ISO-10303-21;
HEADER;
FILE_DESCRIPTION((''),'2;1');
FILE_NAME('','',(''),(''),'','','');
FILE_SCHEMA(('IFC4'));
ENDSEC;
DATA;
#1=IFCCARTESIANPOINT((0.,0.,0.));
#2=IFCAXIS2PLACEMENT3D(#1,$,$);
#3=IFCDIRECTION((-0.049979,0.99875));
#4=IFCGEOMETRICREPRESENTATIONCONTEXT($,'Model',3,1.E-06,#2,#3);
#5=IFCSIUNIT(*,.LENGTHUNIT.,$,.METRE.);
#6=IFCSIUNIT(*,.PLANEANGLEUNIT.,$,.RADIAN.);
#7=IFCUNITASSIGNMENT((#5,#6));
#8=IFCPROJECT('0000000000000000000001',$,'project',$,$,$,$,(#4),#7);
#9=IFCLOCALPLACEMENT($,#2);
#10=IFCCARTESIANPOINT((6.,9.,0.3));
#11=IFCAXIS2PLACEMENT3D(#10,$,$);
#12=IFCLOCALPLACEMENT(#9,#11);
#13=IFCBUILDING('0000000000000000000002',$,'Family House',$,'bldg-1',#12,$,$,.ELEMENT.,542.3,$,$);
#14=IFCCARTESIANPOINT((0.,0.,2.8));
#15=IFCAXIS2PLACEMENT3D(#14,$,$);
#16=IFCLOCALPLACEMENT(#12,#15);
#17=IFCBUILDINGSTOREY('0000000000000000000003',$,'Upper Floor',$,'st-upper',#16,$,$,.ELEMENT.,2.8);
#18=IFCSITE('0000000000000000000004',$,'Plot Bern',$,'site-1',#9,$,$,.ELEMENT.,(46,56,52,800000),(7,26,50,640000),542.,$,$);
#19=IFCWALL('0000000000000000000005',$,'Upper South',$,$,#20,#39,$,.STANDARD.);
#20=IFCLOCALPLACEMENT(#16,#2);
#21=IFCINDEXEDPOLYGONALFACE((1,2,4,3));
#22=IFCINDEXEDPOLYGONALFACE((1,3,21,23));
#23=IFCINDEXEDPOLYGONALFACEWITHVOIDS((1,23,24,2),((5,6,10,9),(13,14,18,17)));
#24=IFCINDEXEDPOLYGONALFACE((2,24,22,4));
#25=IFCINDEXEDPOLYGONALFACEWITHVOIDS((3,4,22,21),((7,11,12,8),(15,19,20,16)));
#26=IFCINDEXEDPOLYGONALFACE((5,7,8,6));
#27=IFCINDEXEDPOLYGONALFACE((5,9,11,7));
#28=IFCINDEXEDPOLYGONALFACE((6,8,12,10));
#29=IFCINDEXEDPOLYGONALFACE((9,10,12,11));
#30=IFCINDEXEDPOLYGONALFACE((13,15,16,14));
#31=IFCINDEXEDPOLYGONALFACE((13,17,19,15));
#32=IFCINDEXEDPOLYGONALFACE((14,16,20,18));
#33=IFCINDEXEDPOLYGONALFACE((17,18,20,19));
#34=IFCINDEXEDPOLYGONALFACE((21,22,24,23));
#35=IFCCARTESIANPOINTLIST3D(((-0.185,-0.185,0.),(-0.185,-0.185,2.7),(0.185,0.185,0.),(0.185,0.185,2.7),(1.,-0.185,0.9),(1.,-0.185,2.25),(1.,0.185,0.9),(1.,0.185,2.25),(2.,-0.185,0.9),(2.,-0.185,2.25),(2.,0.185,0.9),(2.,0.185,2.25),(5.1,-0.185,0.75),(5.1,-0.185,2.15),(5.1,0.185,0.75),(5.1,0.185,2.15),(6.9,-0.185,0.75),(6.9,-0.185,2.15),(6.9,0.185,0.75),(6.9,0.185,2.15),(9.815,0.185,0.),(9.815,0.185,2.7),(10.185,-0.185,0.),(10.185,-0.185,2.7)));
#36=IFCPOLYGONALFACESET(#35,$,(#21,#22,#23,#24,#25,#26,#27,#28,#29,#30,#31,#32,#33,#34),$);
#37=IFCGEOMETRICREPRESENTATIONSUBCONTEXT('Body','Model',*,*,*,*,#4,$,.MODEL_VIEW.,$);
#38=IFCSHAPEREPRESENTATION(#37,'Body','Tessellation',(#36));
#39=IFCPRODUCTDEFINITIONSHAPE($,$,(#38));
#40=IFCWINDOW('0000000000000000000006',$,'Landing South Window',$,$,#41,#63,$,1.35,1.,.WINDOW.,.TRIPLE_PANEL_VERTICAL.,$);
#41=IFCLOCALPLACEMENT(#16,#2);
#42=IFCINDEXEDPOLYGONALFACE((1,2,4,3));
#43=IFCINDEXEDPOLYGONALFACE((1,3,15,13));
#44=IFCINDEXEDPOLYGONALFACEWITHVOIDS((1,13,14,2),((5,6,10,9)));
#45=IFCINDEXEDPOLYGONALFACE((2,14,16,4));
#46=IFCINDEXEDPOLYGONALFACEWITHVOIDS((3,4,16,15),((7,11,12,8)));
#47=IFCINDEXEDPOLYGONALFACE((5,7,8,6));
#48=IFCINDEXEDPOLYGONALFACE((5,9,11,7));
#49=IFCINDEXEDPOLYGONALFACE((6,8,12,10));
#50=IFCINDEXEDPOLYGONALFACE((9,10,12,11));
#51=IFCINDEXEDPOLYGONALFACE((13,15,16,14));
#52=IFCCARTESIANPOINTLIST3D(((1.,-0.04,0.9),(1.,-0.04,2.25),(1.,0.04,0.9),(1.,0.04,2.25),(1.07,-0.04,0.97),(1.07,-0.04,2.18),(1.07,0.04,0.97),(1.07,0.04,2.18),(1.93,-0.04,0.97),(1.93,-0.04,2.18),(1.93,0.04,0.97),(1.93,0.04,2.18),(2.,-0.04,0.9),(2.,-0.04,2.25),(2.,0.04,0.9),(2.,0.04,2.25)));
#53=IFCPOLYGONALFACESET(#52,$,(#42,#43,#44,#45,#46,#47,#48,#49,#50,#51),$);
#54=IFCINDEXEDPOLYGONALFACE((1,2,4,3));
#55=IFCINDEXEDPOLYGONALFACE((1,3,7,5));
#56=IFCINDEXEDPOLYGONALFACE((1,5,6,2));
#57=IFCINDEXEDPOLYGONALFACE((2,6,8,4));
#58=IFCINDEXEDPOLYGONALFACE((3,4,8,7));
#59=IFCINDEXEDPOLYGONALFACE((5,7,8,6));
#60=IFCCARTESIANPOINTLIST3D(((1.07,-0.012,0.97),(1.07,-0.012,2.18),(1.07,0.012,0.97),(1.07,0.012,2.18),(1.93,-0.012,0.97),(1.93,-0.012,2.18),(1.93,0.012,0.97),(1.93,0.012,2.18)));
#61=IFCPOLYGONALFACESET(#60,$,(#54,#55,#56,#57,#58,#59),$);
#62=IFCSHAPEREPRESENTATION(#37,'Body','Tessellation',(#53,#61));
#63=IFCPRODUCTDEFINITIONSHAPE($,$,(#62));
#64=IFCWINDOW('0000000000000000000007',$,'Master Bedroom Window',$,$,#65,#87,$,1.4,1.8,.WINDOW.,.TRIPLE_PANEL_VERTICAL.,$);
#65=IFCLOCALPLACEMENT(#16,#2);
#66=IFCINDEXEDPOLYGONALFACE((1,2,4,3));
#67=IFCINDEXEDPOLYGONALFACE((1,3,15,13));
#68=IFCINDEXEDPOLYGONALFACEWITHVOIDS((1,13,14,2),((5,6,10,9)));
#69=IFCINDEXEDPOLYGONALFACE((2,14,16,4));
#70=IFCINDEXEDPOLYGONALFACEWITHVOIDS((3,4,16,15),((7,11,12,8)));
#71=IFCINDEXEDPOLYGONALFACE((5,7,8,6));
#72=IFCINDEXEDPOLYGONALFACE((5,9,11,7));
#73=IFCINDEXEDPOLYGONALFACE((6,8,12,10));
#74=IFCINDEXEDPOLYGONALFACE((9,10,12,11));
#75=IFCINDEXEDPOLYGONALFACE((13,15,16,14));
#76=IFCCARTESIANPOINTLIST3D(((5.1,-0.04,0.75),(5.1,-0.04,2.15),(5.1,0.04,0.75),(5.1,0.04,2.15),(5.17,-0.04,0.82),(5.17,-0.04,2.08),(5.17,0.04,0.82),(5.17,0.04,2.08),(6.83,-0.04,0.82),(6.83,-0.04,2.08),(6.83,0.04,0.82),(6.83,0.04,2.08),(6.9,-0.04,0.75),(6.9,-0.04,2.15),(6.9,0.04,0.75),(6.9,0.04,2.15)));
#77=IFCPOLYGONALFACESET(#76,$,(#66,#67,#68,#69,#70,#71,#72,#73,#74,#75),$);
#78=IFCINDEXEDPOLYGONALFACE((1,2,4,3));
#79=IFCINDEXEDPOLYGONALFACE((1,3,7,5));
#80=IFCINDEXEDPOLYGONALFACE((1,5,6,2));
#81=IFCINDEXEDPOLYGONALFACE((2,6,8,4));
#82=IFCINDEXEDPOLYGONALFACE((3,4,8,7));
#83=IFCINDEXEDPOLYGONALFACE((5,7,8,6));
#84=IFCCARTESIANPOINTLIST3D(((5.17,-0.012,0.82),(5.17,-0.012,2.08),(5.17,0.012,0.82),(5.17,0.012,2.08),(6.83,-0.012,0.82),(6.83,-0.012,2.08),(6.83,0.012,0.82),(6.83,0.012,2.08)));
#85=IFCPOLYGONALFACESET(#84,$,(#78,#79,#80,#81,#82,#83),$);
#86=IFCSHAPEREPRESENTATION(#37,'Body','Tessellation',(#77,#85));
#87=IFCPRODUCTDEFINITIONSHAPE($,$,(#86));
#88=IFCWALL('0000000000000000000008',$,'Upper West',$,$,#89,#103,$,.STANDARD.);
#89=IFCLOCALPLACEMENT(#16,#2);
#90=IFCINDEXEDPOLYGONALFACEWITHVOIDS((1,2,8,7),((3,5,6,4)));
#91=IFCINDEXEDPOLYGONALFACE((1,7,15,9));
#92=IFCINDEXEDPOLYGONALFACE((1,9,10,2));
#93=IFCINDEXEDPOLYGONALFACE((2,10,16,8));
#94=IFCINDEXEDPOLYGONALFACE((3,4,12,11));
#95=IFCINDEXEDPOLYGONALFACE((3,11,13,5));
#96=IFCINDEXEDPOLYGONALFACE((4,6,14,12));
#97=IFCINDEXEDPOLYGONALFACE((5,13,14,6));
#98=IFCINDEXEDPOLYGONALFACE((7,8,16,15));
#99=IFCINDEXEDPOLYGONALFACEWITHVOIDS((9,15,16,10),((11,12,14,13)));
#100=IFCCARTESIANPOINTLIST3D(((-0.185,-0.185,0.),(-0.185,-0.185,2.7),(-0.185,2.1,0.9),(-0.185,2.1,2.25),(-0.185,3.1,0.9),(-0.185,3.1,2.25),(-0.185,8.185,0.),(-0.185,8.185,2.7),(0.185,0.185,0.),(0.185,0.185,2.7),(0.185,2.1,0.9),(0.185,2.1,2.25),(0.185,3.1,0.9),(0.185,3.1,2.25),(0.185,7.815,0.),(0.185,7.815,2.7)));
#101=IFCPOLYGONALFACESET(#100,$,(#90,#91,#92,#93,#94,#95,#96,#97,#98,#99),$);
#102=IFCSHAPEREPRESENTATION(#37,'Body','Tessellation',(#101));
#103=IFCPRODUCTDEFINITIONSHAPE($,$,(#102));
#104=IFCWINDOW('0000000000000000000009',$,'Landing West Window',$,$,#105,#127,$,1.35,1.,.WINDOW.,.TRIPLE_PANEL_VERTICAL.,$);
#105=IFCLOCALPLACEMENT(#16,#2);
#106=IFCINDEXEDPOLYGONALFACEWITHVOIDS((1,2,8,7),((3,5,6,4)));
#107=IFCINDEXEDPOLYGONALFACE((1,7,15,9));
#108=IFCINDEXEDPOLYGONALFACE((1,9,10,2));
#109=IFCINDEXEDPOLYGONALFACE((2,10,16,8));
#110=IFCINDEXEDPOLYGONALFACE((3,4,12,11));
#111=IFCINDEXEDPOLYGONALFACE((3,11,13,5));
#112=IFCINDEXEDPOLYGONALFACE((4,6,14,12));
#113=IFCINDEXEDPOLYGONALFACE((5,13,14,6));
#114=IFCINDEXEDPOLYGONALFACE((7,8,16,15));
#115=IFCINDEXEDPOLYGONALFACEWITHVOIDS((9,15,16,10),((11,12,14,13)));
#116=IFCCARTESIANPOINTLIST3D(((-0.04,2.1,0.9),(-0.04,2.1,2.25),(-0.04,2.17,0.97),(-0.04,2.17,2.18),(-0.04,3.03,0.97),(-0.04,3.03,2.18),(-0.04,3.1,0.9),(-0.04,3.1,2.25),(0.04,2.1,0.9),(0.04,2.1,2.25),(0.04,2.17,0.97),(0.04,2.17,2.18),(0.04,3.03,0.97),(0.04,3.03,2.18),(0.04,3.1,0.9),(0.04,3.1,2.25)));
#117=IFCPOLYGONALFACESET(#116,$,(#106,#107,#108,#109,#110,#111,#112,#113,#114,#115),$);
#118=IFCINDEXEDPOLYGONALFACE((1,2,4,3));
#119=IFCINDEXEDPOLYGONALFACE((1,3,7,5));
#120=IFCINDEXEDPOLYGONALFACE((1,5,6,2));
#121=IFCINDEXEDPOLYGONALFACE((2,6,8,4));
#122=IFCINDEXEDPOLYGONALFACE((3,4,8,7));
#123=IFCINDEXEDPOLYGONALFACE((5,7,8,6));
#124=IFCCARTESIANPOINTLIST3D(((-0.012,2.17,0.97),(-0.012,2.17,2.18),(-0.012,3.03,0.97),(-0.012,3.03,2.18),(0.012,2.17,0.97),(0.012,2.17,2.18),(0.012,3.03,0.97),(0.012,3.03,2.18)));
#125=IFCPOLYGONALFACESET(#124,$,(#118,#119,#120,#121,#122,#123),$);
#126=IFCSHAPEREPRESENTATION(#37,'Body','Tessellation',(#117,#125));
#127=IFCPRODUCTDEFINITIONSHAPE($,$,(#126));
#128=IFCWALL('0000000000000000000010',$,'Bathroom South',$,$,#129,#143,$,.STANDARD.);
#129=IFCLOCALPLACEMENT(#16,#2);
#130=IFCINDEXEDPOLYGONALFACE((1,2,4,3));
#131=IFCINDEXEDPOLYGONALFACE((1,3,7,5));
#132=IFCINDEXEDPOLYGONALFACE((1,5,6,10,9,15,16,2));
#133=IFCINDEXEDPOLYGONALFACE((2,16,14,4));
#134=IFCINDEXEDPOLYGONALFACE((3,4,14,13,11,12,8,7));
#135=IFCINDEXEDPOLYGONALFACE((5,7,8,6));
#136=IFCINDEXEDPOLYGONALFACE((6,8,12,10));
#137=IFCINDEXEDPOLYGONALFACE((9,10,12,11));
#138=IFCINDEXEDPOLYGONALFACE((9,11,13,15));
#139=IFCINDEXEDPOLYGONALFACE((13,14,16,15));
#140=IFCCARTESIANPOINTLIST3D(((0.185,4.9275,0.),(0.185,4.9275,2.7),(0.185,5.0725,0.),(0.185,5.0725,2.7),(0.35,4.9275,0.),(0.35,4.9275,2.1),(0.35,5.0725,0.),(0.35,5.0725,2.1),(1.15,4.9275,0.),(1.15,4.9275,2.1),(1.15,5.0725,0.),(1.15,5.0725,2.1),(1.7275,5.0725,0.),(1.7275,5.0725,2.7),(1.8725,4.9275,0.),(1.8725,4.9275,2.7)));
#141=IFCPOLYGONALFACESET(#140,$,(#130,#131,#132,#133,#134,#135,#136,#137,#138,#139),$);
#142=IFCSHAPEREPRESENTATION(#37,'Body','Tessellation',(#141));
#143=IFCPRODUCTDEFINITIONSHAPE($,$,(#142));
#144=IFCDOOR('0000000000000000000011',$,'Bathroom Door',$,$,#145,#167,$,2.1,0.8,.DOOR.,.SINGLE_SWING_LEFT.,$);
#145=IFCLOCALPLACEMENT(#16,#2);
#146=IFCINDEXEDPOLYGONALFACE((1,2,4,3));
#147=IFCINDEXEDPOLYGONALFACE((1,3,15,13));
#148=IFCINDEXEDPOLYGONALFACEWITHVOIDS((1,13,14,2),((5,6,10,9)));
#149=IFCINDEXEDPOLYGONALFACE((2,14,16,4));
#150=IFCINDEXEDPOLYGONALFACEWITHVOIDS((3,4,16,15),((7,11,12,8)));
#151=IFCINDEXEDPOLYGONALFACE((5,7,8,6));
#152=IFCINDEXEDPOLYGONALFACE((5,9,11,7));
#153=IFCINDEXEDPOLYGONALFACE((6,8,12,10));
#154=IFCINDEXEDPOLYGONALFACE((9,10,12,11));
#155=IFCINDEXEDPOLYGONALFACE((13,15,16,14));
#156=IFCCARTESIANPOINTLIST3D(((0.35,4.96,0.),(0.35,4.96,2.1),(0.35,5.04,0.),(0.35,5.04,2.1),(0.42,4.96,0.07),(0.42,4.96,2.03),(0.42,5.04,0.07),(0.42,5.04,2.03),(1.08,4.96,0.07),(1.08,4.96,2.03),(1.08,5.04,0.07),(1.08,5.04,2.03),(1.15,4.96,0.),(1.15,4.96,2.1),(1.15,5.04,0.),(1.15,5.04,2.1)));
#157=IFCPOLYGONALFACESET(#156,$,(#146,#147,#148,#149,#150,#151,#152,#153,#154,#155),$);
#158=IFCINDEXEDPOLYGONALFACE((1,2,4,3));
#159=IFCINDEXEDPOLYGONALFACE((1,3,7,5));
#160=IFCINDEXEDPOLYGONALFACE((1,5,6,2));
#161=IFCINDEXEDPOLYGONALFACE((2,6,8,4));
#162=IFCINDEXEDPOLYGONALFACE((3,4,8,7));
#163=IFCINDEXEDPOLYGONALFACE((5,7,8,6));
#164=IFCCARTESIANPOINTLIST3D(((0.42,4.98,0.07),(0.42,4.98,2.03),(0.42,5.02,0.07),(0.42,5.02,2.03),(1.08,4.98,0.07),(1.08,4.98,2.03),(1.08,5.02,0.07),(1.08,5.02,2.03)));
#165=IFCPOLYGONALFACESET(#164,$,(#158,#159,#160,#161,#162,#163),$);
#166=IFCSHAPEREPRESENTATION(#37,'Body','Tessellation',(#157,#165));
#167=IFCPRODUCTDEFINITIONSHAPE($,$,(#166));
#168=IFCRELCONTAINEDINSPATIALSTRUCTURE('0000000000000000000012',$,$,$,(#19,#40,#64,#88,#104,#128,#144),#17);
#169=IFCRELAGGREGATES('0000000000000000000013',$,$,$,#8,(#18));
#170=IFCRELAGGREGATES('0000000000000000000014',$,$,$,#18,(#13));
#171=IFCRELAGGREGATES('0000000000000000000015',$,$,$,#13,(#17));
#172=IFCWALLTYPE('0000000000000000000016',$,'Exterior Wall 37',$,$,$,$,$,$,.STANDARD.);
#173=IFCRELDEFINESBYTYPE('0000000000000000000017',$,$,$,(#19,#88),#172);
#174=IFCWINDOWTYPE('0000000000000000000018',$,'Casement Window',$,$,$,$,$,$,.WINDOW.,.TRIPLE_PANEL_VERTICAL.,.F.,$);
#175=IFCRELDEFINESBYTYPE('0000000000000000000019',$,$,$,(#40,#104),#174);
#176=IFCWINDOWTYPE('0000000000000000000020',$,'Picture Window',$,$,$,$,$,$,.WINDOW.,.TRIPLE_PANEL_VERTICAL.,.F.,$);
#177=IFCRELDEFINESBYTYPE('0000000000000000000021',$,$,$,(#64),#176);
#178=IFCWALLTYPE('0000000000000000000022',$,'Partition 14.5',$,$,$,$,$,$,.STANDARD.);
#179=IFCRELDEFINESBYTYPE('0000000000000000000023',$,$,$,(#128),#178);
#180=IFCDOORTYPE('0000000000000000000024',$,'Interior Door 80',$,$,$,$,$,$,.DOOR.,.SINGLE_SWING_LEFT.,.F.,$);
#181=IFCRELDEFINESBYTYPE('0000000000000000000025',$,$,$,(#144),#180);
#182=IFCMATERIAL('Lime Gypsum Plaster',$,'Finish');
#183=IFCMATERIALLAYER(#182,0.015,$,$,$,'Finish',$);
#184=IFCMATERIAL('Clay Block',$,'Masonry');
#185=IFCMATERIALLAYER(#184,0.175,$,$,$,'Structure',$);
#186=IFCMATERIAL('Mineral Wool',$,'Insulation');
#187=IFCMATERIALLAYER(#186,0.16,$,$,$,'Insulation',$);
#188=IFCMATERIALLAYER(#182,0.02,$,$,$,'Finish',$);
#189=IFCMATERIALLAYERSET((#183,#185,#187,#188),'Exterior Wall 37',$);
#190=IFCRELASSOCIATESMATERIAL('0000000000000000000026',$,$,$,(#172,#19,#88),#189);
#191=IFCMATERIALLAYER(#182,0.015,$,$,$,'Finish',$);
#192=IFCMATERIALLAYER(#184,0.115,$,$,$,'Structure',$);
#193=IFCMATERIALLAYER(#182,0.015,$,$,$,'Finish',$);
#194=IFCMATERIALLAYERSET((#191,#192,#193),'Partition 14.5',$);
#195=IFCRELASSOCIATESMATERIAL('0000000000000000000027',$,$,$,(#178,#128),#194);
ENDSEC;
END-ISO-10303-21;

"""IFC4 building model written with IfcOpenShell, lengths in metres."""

from ifc_helpers import new_model, si_unit, direction, frame, frame_2d, origin, origin_2d, place, context, subcontext, project, spatial, polyline, rectangle, outline, extrude, material, layer, layer_set, layer_usage, type_object, element, fill, save


model = new_model("IFC4")

# Units and contexts
model_context = context("Model", 3, precision=1e-06, world=origin(), true_north=direction((-0.049979, 0.99875)))
body_context = subcontext(model_context, "Body", "Model", "MODEL_VIEW")
ifc_project = project(units=[si_unit("LENGTHUNIT", "METRE"), si_unit("PLANEANGLEUNIT", "RADIAN")], contexts=[model_context])

# Site, building, storey
site_placement = place(None, origin())
site = spatial("IfcSite", under=ifc_project, at=site_placement, Name="Plot Bern", ObjectType="site-1", CompositionType="ELEMENT", RefLatitude=(46, 56, 52, 800000), RefLongitude=(7, 26, 50, 640000), RefElevation=542.0)
building_placement = place(site_placement, frame((6.0, 9.0, 0.3)))
building = spatial("IfcBuilding", under=site, at=building_placement, Name="Family House", ObjectType="bldg-1", CompositionType="ELEMENT", ElevationOfRefHeight=542.3)
storey_placement = place(building_placement, frame((0.0, 0.0, 2.8)))
storey = spatial("IfcBuildingStorey", under=building, at=storey_placement, Name="Upper Floor", ObjectType="st-upper", CompositionType="ELEMENT", Elevation=2.8)

# Shared definitions
ifc_material_1 = material(Name="Mineral Wool", Category="Insulation")

# Shared definitions
ifc_material_2 = material(Name="Lime Gypsum Plaster", Category="Finish")
ifc_layer_1 = layer(ifc_material_2, 0.015, Category="Finish")
ifc_material_3 = material(Name="Clay Block", Category="Masonry")
ifc_layer_2 = layer(ifc_material_3, 0.175, Category="Structure")
ifc_layer_3 = layer(ifc_material_1, 0.16, Category="Insulation")
ifc_layer_4 = layer(ifc_material_2, 0.02, Category="Finish")
ifc_layer_set_1 = layer_set([ifc_layer_1, ifc_layer_2, ifc_layer_3, ifc_layer_4], Name="Exterior Wall 37")
wall_type_1 = type_object("IfcWallType", Name="Exterior Wall 37", PredefinedType="STANDARD", material=ifc_layer_set_1)

# Shared definitions
window_type_1 = type_object("IfcWindowType", Name="Casement Window", ParameterTakesPrecedence=False, PartitioningType="TRIPLE_PANEL_VERTICAL", PredefinedType="WINDOW")

# Wall, openings, windows
ifc_layer_usage_1 = layer_usage(ifc_layer_set_1, "AXIS2", "NEGATIVE", 0.185)
wall_1_placement = place(storey_placement, origin())
wall_1 = element("IfcWall", 1, at=wall_1_placement, inside=storey, type_object=wall_type_1, material=ifc_layer_usage_1, Name="Upper South", PredefinedType="STANDARD", context=body_context, shape_type="SweptSolid", body=[
    extrude(outline(polyline([(-0.185, -0.185), (10.185, -0.185), (9.815, 0.185), (0.185, 0.185), (-0.185, -0.185)])), origin(), (0.0, 0.0, 1.0), 2.7),
])
opening_1_placement = place(wall_1_placement, frame((1.5, 0.0, 0.9), z_axis=(0.0, 0.0, 1.0), x_axis=(1.0, 0.0, 0.0)))
opening_1 = element("IfcOpeningElement", 2, at=opening_1_placement, cuts=wall_1, PredefinedType="OPENING", context=body_context, shape_type="SweptSolid", body=[
    extrude(rectangle(XDim=1.0, YDim=0.37, at=origin_2d()), origin(), (0.0, 0.0, 1.0), 1.35),
])
opening_2_placement = place(wall_1_placement, frame((6.0, 0.0, 0.75), z_axis=(0.0, 0.0, 1.0), x_axis=(1.0, 0.0, 0.0)))
opening_2 = element("IfcOpeningElement", 3, at=opening_2_placement, cuts=wall_1, PredefinedType="OPENING", context=body_context, shape_type="SweptSolid", body=[
    extrude(rectangle(XDim=1.8, YDim=0.37, at=origin_2d()), origin(), (0.0, 0.0, 1.0), 1.4),
])
window_1_placement = place(opening_1_placement, frame((0.0, 0.0, 0.0), z_axis=(0.0, -1.0, 0.0), x_axis=(1.0, 0.0, 0.0)))
window_1 = element("IfcWindow", 4, at=window_1_placement, inside=storey, type_object=window_type_1, Name="Landing South Window", OverallHeight=1.35, OverallWidth=1.0, PartitioningType="TRIPLE_PANEL_VERTICAL", PredefinedType="WINDOW", context=body_context, shape_type="SweptSolid", body=[
    extrude(outline(polyline([(-0.5, 0.0), (0.5, 0.0), (0.5, 1.35), (-0.5, 1.35), (-0.5, 0.0)]), holes=[polyline([(-0.43, 0.07), (0.43, 0.07), (0.43, 1.28), (-0.43, 1.28), (-0.43, 0.07)])]), frame((0.0, 0.0, -0.04)), (0.0, 0.0, 1.0), 0.08),
    extrude(rectangle(XDim=0.86, YDim=1.21, at=frame_2d((0.0, 0.675))), frame((0.0, 0.0, -0.012)), (0.0, 0.0, 1.0), 0.024),
])
fill(opening_1, window_1)
window_type_2 = type_object("IfcWindowType", Name="Picture Window", ParameterTakesPrecedence=False, PartitioningType="TRIPLE_PANEL_VERTICAL", PredefinedType="WINDOW")
window_2_placement = place(opening_2_placement, frame((0.0, 0.0, 0.0), z_axis=(0.0, -1.0, 0.0), x_axis=(1.0, 0.0, 0.0)))
window_2 = element("IfcWindow", 5, at=window_2_placement, inside=storey, type_object=window_type_2, Name="Master Bedroom Window", OverallHeight=1.4, OverallWidth=1.8, PartitioningType="TRIPLE_PANEL_VERTICAL", PredefinedType="WINDOW", context=body_context, shape_type="SweptSolid", body=[
    extrude(outline(polyline([(-0.9, 0.0), (0.9, 0.0), (0.9, 1.4), (-0.9, 1.4), (-0.9, 0.0)]), holes=[polyline([(-0.83, 0.07), (0.83, 0.07), (0.83, 1.33), (-0.83, 1.33), (-0.83, 0.07)])]), frame((0.0, 0.0, -0.04)), (0.0, 0.0, 1.0), 0.08),
    extrude(rectangle(XDim=1.66, YDim=1.26, at=frame_2d((0.0, 0.7))), frame((0.0, 0.0, -0.012)), (0.0, 0.0, 1.0), 0.024),
])
fill(opening_2, window_2)

# Wall, opening, window
ifc_layer_usage_2 = layer_usage(ifc_layer_set_1, "AXIS2", "NEGATIVE", 0.185)
wall_2_placement = place(storey_placement, origin())
wall_2 = element("IfcWall", 6, at=wall_2_placement, inside=storey, type_object=wall_type_1, material=ifc_layer_usage_2, Name="Upper West", PredefinedType="STANDARD", context=body_context, shape_type="SweptSolid", body=[
    extrude(outline(polyline([(-0.185, 8.185), (-0.185, -0.185), (0.185, 0.185), (0.185, 7.815), (-0.185, 8.185)])), origin(), (0.0, 0.0, 1.0), 2.7),
])
opening_3_placement = place(wall_2_placement, frame((0.0, 2.6, 0.9), z_axis=(0.0, 0.0, 1.0), x_axis=(0.0, -1.0, 0.0)))
opening_3 = element("IfcOpeningElement", 7, at=opening_3_placement, cuts=wall_2, PredefinedType="OPENING", context=body_context, shape_type="SweptSolid", body=[
    extrude(rectangle(XDim=1.0, YDim=0.37, at=origin_2d()), origin(), (0.0, 0.0, 1.0), 1.35),
])
window_3_placement = place(opening_3_placement, frame((0.0, 0.0, 0.0), z_axis=(0.0, -1.0, 0.0), x_axis=(1.0, 0.0, 0.0)))
window_3 = element("IfcWindow", 8, at=window_3_placement, inside=storey, type_object=window_type_1, Name="Landing West Window", OverallHeight=1.35, OverallWidth=1.0, PartitioningType="TRIPLE_PANEL_VERTICAL", PredefinedType="WINDOW", context=body_context, shape_type="SweptSolid", body=[
    extrude(outline(polyline([(-0.5, 0.0), (0.5, 0.0), (0.5, 1.35), (-0.5, 1.35), (-0.5, 0.0)]), holes=[polyline([(-0.43, 0.07), (0.43, 0.07), (0.43, 1.28), (-0.43, 1.28), (-0.43, 0.07)])]), frame((0.0, 0.0, -0.04)), (0.0, 0.0, 1.0), 0.08),
    extrude(rectangle(XDim=0.86, YDim=1.21, at=frame_2d((0.0, 0.675))), frame((0.0, 0.0, -0.012)), (0.0, 0.0, 1.0), 0.024),
])
fill(opening_3, window_3)

# Wall, opening, door
ifc_layer_5 = layer(ifc_material_2, 0.015, Category="Finish")
ifc_layer_6 = layer(ifc_material_3, 0.115, Category="Structure")
ifc_layer_7 = layer(ifc_material_2, 0.015, Category="Finish")
ifc_layer_set_2 = layer_set([ifc_layer_5, ifc_layer_6, ifc_layer_7], Name="Partition 14.5")
ifc_layer_usage_3 = layer_usage(ifc_layer_set_2, "AXIS2", "NEGATIVE", 0.0725)
wall_type_2 = type_object("IfcWallType", Name="Partition 14.5", PredefinedType="STANDARD", material=ifc_layer_set_2)
wall_3_placement = place(storey_placement, origin())
wall_3 = element("IfcWall", 9, at=wall_3_placement, inside=storey, type_object=wall_type_2, material=ifc_layer_usage_3, Name="Bathroom South", PredefinedType="STANDARD", context=body_context, shape_type="SweptSolid", body=[
    extrude(outline(polyline([(0.185, 4.9275), (1.8725, 4.9275), (1.7275, 5.0725), (0.185, 5.0725), (0.185, 4.9275)])), origin(), (0.0, 0.0, 1.0), 2.7),
])
opening_4_placement = place(wall_3_placement, frame((0.75, 5.0, 0.0), z_axis=(0.0, 0.0, 1.0), x_axis=(1.0, 0.0, 0.0)))
opening_4 = element("IfcOpeningElement", 10, at=opening_4_placement, cuts=wall_3, PredefinedType="OPENING", context=body_context, shape_type="SweptSolid", body=[
    extrude(rectangle(XDim=0.8, YDim=0.145, at=origin_2d()), origin(), (0.0, 0.0, 1.0), 2.1),
])
door_type_1 = type_object("IfcDoorType", Name="Interior Door 80", OperationType="SINGLE_SWING_LEFT", ParameterTakesPrecedence=False, PredefinedType="DOOR")
door_1_placement = place(opening_4_placement, frame((0.0, 0.0, 0.0), z_axis=(0.0, -1.0, 0.0), x_axis=(1.0, 0.0, 0.0)))
door_1 = element("IfcDoor", 11, at=door_1_placement, inside=storey, type_object=door_type_1, Name="Bathroom Door", OperationType="SINGLE_SWING_LEFT", OverallHeight=2.1, OverallWidth=0.8, PredefinedType="DOOR", context=body_context, shape_type="SweptSolid", body=[
    extrude(outline(polyline([(-0.4, 0.0), (0.4, 0.0), (0.4, 2.1), (-0.4, 2.1), (-0.4, 0.0)]), holes=[polyline([(-0.33, 0.07), (0.33, 0.07), (0.33, 2.03), (-0.33, 2.03), (-0.33, 0.07)])]), frame((0.0, 0.0, -0.04)), (0.0, 0.0, 1.0), 0.08),
    extrude(rectangle(XDim=0.66, YDim=1.96, at=frame_2d((0.0, 1.05))), frame((0.0, 0.0, -0.02)), (0.0, 0.0, 1.0), 0.04),
])
fill(opening_4, door_1)

save(model, "model.ifc")
